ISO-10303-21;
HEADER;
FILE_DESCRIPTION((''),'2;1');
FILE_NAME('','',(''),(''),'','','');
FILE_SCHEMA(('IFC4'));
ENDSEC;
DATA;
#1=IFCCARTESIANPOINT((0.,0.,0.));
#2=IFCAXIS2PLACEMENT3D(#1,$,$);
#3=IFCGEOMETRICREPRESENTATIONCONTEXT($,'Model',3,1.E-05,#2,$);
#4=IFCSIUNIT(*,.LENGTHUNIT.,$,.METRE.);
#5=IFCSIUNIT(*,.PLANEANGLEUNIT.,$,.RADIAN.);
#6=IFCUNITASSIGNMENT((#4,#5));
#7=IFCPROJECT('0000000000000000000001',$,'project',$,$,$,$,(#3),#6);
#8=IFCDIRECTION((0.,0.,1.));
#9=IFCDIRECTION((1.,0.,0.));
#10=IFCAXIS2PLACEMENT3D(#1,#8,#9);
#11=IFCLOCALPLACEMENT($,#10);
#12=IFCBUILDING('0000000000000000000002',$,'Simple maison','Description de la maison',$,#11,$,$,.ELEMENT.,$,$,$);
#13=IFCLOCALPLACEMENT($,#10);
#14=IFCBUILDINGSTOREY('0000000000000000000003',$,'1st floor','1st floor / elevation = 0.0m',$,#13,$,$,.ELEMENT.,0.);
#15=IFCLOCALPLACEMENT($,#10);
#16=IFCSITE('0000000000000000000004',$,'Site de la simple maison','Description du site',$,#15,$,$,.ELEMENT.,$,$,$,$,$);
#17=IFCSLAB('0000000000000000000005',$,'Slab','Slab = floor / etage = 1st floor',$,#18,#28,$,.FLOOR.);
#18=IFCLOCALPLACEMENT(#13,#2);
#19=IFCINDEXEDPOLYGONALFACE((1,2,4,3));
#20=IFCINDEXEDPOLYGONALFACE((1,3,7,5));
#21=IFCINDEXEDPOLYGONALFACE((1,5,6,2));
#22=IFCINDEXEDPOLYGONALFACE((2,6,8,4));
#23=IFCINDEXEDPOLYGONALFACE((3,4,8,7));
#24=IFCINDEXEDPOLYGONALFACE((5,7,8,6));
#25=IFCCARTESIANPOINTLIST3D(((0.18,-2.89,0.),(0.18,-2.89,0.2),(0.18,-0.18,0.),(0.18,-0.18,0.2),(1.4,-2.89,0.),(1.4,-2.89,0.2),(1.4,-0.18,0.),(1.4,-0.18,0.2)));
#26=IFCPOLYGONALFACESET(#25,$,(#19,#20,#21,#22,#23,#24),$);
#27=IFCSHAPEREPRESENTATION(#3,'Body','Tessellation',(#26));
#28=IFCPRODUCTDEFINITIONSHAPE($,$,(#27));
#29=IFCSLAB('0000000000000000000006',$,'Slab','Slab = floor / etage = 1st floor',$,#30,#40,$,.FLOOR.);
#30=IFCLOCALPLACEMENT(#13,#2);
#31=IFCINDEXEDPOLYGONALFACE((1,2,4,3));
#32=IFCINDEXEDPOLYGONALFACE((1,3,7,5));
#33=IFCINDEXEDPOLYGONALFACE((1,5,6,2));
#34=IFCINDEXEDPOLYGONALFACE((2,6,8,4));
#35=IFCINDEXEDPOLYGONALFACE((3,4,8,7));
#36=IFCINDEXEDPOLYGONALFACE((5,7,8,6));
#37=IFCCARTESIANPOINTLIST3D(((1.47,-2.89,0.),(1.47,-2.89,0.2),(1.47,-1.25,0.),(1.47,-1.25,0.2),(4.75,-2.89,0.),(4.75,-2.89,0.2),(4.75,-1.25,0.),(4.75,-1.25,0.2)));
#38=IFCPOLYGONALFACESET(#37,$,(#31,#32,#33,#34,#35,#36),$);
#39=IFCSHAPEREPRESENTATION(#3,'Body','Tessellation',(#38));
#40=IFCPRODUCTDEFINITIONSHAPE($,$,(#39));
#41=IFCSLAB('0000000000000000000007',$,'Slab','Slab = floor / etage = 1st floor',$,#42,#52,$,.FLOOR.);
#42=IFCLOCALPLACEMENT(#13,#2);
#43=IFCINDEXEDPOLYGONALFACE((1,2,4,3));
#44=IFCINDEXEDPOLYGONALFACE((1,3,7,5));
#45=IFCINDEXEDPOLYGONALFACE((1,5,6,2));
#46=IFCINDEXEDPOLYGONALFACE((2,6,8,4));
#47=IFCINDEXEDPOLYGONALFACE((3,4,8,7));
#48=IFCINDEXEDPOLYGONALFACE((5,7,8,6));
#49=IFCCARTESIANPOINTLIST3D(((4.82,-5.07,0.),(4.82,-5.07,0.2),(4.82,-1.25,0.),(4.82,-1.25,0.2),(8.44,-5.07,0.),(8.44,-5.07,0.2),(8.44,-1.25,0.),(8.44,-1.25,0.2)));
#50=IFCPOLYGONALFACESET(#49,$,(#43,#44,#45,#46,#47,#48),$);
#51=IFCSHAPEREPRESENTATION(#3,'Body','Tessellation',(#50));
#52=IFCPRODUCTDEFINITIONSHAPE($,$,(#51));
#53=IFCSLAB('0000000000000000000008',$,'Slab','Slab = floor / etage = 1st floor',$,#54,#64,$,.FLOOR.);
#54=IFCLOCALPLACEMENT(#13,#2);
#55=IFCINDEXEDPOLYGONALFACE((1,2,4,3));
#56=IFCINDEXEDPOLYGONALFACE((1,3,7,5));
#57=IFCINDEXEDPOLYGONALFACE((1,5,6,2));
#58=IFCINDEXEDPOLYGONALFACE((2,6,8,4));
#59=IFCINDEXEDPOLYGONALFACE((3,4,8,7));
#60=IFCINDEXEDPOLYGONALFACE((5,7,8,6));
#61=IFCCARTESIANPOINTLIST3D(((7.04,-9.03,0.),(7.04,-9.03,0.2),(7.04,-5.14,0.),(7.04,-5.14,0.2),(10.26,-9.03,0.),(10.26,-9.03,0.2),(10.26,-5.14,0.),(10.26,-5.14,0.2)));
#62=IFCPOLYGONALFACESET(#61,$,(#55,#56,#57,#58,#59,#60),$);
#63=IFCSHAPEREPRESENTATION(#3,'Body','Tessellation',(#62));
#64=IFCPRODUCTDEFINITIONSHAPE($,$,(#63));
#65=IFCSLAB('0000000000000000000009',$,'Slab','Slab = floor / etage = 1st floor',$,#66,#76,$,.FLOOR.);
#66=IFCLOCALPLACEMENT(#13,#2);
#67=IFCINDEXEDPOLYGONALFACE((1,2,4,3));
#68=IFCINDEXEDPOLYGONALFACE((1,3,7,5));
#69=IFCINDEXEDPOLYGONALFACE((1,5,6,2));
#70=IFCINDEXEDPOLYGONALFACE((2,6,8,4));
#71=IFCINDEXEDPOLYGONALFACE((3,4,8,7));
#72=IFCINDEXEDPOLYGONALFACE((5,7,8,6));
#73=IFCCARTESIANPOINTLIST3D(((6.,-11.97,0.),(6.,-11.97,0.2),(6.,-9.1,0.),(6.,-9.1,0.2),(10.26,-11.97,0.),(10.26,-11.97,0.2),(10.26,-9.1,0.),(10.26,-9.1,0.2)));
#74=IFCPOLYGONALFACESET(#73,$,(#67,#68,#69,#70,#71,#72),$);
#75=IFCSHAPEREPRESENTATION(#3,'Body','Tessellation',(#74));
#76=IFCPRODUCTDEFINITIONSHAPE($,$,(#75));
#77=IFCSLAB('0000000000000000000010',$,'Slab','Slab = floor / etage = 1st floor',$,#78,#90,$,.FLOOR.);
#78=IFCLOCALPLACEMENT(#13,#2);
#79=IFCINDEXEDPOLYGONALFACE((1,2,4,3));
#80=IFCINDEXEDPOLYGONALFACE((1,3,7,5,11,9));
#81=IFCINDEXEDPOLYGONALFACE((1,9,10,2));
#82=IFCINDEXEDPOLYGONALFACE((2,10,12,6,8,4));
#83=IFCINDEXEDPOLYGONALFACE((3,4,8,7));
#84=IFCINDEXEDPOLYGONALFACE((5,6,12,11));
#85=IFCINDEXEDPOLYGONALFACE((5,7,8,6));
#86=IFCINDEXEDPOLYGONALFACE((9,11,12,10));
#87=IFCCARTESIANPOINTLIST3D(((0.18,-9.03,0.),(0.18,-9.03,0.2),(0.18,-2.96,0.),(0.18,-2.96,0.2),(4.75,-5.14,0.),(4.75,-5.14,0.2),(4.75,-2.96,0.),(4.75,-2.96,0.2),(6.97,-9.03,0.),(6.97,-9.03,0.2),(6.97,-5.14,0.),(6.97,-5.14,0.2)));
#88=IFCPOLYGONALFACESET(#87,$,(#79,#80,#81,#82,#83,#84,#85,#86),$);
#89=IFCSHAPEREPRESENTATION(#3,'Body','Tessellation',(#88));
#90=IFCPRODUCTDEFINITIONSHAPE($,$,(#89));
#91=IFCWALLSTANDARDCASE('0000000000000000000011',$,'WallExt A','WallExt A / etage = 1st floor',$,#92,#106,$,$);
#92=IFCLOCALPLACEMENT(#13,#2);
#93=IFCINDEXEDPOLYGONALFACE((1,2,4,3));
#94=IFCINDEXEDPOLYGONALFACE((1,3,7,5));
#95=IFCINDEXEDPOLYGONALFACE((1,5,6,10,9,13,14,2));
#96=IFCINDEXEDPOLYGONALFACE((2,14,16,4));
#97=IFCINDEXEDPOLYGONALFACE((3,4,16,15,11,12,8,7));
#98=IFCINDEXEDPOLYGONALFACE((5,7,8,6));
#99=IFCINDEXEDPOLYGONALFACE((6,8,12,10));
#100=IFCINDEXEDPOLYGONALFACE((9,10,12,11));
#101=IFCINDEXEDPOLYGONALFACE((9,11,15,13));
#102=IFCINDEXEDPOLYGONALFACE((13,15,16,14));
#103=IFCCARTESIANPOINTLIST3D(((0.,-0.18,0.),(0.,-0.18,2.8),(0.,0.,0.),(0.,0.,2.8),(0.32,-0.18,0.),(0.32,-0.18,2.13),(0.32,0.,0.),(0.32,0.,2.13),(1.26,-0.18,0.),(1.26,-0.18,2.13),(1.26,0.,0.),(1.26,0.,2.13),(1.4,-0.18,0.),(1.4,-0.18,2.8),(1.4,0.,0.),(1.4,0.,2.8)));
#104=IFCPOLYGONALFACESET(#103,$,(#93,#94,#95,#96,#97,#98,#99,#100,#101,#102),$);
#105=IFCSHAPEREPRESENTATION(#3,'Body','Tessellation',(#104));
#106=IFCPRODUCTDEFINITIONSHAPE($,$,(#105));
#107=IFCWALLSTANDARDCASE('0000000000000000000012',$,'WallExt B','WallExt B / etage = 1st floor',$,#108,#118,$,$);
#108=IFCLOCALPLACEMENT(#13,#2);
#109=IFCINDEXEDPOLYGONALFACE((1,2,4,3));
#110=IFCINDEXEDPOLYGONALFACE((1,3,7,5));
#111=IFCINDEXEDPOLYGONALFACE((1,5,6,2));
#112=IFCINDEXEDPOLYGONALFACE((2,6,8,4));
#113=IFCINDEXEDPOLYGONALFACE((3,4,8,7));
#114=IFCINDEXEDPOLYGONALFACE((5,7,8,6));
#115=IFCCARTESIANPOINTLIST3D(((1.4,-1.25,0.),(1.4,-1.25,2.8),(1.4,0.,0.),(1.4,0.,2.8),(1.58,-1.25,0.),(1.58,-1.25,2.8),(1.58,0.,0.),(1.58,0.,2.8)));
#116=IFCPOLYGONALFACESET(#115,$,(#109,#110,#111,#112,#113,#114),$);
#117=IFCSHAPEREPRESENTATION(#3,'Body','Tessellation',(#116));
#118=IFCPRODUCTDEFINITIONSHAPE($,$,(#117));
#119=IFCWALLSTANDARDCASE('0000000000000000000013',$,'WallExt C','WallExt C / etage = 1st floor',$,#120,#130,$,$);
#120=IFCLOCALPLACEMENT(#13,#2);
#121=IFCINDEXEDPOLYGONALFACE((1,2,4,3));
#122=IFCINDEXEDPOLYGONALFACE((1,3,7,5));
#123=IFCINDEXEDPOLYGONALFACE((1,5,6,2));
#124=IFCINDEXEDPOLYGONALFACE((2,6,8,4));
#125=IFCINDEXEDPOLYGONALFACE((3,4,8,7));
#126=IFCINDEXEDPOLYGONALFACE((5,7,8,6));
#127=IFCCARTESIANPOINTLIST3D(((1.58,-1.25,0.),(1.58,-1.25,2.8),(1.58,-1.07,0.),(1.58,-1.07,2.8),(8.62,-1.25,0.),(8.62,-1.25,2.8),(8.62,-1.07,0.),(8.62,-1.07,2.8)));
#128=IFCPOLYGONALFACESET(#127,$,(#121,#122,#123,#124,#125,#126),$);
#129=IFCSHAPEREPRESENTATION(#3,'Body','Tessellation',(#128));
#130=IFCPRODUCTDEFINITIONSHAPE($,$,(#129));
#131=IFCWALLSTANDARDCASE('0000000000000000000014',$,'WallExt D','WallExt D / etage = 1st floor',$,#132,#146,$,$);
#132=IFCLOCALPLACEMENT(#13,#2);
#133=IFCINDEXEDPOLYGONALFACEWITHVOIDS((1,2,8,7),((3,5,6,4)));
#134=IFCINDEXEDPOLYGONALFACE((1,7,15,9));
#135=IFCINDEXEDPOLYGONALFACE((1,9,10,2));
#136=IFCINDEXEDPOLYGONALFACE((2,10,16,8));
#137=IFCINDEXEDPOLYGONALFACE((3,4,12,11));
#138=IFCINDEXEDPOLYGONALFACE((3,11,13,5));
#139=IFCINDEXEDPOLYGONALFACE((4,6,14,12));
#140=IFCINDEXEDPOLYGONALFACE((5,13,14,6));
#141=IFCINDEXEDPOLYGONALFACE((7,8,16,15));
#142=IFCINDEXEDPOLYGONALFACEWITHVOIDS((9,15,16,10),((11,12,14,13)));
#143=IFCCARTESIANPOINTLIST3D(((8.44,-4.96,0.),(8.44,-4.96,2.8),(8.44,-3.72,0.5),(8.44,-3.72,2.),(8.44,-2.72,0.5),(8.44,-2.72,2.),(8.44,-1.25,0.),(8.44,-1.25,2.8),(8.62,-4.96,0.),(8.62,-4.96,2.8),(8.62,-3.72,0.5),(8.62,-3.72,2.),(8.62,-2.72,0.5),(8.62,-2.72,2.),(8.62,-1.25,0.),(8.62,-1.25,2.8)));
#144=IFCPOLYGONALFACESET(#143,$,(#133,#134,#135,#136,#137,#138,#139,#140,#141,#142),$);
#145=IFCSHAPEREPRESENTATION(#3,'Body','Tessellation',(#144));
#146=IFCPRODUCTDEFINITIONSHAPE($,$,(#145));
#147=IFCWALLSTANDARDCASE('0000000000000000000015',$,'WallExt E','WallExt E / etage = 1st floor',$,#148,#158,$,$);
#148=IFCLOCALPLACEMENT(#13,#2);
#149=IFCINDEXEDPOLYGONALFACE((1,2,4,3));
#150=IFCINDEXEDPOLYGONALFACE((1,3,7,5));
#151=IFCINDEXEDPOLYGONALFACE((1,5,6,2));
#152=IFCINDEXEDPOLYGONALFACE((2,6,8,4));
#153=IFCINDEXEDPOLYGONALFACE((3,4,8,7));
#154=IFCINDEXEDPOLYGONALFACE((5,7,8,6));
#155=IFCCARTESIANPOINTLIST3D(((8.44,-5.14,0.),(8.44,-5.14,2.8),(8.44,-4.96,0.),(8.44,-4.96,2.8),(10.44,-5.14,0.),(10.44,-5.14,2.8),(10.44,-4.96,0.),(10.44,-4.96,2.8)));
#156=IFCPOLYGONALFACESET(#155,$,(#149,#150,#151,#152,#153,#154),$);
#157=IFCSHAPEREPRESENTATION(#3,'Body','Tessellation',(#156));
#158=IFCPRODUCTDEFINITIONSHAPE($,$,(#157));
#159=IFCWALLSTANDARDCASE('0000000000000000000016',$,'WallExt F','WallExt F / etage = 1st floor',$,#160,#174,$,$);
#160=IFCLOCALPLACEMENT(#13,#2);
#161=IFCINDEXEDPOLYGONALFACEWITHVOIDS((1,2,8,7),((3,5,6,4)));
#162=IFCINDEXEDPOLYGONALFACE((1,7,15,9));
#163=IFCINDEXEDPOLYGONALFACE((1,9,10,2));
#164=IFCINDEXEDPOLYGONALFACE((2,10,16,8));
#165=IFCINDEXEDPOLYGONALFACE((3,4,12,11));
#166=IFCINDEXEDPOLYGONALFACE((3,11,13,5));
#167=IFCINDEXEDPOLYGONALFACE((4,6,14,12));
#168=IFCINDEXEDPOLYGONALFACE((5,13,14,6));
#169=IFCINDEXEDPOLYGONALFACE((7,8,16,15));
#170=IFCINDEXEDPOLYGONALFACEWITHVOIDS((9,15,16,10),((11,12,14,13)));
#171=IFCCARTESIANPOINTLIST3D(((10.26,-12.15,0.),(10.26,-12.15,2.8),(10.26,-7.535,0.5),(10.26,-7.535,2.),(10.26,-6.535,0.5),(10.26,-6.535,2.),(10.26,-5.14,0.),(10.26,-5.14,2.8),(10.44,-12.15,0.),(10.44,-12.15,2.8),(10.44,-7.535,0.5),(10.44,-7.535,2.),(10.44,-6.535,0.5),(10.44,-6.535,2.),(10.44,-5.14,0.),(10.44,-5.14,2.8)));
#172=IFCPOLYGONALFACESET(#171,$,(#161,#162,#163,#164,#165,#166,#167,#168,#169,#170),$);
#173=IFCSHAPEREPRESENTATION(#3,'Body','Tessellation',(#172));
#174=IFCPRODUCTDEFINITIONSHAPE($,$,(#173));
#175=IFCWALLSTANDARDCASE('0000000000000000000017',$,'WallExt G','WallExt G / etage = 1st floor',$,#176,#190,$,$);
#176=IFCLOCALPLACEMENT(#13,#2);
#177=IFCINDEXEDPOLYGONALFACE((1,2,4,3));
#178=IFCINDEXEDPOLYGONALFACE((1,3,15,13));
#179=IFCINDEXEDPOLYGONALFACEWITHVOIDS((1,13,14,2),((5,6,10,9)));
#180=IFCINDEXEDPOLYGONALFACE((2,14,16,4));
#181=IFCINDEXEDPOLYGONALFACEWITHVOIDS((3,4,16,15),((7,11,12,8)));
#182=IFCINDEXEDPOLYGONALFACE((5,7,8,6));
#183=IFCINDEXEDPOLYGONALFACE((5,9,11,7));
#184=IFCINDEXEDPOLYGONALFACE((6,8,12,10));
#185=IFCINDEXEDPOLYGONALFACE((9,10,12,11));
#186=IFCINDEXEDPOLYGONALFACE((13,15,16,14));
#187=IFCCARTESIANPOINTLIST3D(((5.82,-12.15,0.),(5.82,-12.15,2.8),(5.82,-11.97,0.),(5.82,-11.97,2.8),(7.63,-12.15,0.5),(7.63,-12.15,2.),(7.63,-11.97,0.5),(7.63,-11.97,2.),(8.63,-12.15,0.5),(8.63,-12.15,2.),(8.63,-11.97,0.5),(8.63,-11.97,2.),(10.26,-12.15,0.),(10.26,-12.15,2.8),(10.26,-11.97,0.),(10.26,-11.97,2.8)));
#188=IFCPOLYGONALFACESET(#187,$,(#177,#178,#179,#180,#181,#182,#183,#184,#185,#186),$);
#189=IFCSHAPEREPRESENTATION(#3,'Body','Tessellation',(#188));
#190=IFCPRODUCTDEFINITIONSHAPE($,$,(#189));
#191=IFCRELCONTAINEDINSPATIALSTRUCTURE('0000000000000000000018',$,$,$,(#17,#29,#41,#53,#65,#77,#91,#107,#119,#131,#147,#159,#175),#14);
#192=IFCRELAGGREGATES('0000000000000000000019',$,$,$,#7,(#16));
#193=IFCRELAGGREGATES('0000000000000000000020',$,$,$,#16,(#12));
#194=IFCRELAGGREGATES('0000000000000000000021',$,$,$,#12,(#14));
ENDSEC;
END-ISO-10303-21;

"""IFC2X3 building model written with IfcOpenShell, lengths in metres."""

from ifc_helpers import new_model, si_unit, frame, origin, origin_with_axes, origin_2d_with_axis, place, context, project, spatial, polyline, rectangle, outline, extrude, element, save


model = new_model("IFC2X3")

# Units and contexts
model_context = context("Model", 3, precision=1e-05, world=origin())
ifc_project = project(units=[si_unit("LENGTHUNIT", "METRE"), si_unit("PLANEANGLEUNIT", "RADIAN")], contexts=[model_context])

# Site, building, storey
site_placement = place(None, origin_with_axes())
site = spatial("IfcSite", under=ifc_project, at=site_placement, Name="Site de la simple maison", Description="Description du site", CompositionType="ELEMENT")
building_placement = place(None, origin_with_axes())
building = spatial("IfcBuilding", under=site, at=building_placement, Name="Simple maison", Description="Description de la maison", CompositionType="ELEMENT")
storey_placement = place(None, origin_with_axes())
storey = spatial("IfcBuildingStorey", under=building, at=storey_placement, Name="1st floor", Description="1st floor / elevation = 0.0m", CompositionType="ELEMENT", Elevation=0.0)

# Slabs
slab_1_placement = place(storey_placement, origin_with_axes())
element("IfcSlab", 1, at=slab_1_placement, inside=storey, Name="Slab", Description="Slab = floor / etage = 1st floor", PredefinedType="FLOOR", context=model_context, shape_type="SweptSolid", body=[
    extrude(outline(polyline([(0.18, -0.18), (1.4, -0.18), (1.4, -2.89), (0.18, -2.89)])), origin(), (0.0, 0.0, 1.0), 0.2),
])
slab_2_placement = place(storey_placement, origin_with_axes())
element("IfcSlab", 2, at=slab_2_placement, inside=storey, Name="Slab", Description="Slab = floor / etage = 1st floor", PredefinedType="FLOOR", context=model_context, shape_type="SweptSolid", body=[
    extrude(outline(polyline([(1.47, -1.25), (4.75, -1.25), (4.75, -2.89), (1.47, -2.89)])), origin(), (0.0, 0.0, 1.0), 0.2),
])
slab_3_placement = place(storey_placement, origin_with_axes())
element("IfcSlab", 3, at=slab_3_placement, inside=storey, Name="Slab", Description="Slab = floor / etage = 1st floor", PredefinedType="FLOOR", context=model_context, shape_type="SweptSolid", body=[
    extrude(outline(polyline([(4.82, -1.25), (8.44, -1.25), (8.44, -5.07), (4.82, -5.07)])), origin(), (0.0, 0.0, 1.0), 0.2),
])
slab_4_placement = place(storey_placement, origin_with_axes())
element("IfcSlab", 4, at=slab_4_placement, inside=storey, Name="Slab", Description="Slab = floor / etage = 1st floor", PredefinedType="FLOOR", context=model_context, shape_type="SweptSolid", body=[
    extrude(outline(polyline([(7.04, -5.14), (10.26, -5.14), (10.26, -9.03), (7.04, -9.03)])), origin(), (0.0, 0.0, 1.0), 0.2),
])
slab_5_placement = place(storey_placement, origin_with_axes())
element("IfcSlab", 5, at=slab_5_placement, inside=storey, Name="Slab", Description="Slab = floor / etage = 1st floor", PredefinedType="FLOOR", context=model_context, shape_type="SweptSolid", body=[
    extrude(outline(polyline([(6.0, -9.1), (10.26, -9.1), (10.26, -11.97), (6.0, -11.97)])), origin(), (0.0, 0.0, 1.0), 0.2),
])
slab_6_placement = place(storey_placement, origin_with_axes())
element("IfcSlab", 6, at=slab_6_placement, inside=storey, Name="Slab", Description="Slab = floor / etage = 1st floor", PredefinedType="FLOOR", context=model_context, shape_type="SweptSolid", body=[
    extrude(outline(polyline([(0.18, -2.96), (4.75, -2.96), (4.75, -5.14), (6.97, -5.14), (6.97, -9.03), (0.18, -9.03)])), origin(), (0.0, 0.0, 1.0), 0.2),
])

# Wall, opening
wall_1_placement = place(storey_placement, frame((0.0, -0.09, 0.0), z_axis=(0.0, 0.0, 1.0), x_axis=(1.0, 0.0, 0.0)))
wall_1 = element("IfcWallStandardCase", 7, at=wall_1_placement, inside=storey, Name="WallExt A", Description="WallExt A / etage = 1st floor", context=model_context, shape_type="SweptSolid", body=[
    extrude(outline(polyline([(0.0, 0.09), (1.4, 0.09), (1.4, -0.09), (0.0, -0.09)])), origin(), (0.0, 0.0, 1.0), 2.8),
])
opening_1_placement = place(wall_1_placement, frame((0.32, -0.09, 0.0), z_axis=(0.0, 0.0, 1.0), x_axis=(1.0, 0.0, 0.0)))
element("IfcOpeningElement", 8, at=opening_1_placement, cuts=wall_1, context=model_context, shape_type="SweptSolid", body=[
    extrude(rectangle(XDim=2.13, YDim=0.94, at=origin_2d_with_axis()), frame((0.47, 0.0, 1.065), z_axis=(0.0, 1.0, 0.0), x_axis=(0.0, 0.0, 1.0)), (0.0, 0.0, 1.0), 0.18),
])

# Walls
wall_2_placement = place(storey_placement, frame((1.49, 0.0, 0.0), z_axis=(0.0, 0.0, 1.0), x_axis=(0.0, -1.0, 0.0)))
element("IfcWallStandardCase", 9, at=wall_2_placement, inside=storey, Name="WallExt B", Description="WallExt B / etage = 1st floor", context=model_context, shape_type="SweptSolid", body=[
    extrude(outline(polyline([(0.0, 0.09), (1.25, 0.09), (1.25, -0.09), (0.0, -0.09)])), origin(), (0.0, 0.0, 1.0), 2.8),
])
wall_3_placement = place(storey_placement, frame((1.58, -1.16, 0.0), z_axis=(0.0, 0.0, 1.0), x_axis=(1.0, 0.0, 0.0)))
element("IfcWallStandardCase", 10, at=wall_3_placement, inside=storey, Name="WallExt C", Description="WallExt C / etage = 1st floor", context=model_context, shape_type="SweptSolid", body=[
    extrude(outline(polyline([(0.0, 0.09), (7.04, 0.09), (7.04, -0.09), (0.0, -0.09)])), origin(), (0.0, 0.0, 1.0), 2.8),
])

# Wall, opening
wall_4_placement = place(storey_placement, frame((8.53, -1.25, 0.0), z_axis=(0.0, 0.0, 1.0), x_axis=(0.0, -1.0, 0.0)))
wall_4 = element("IfcWallStandardCase", 11, at=wall_4_placement, inside=storey, Name="WallExt D", Description="WallExt D / etage = 1st floor", context=model_context, shape_type="SweptSolid", body=[
    extrude(outline(polyline([(0.0, 0.09), (3.71, 0.09), (3.71, -0.09), (0.0, -0.09)])), origin(), (0.0, 0.0, 1.0), 2.8),
])
opening_2_placement = place(wall_4_placement, frame((1.47, -0.09, 0.5), z_axis=(0.0, 0.0, 1.0), x_axis=(1.0, 0.0, 0.0)))
element("IfcOpeningElement", 12, at=opening_2_placement, cuts=wall_4, context=model_context, shape_type="SweptSolid", body=[
    extrude(rectangle(XDim=1.5, YDim=1.0, at=origin_2d_with_axis()), frame((0.5, 0.0, 0.75), z_axis=(0.0, 1.0, 0.0), x_axis=(0.0, 0.0, 1.0)), (0.0, 0.0, 1.0), 0.18),
])

# Wall
wall_5_placement = place(storey_placement, frame((8.44, -5.05, 0.0), z_axis=(0.0, 0.0, 1.0), x_axis=(1.0, 0.0, 0.0)))
element("IfcWallStandardCase", 13, at=wall_5_placement, inside=storey, Name="WallExt E", Description="WallExt E / etage = 1st floor", context=model_context, shape_type="SweptSolid", body=[
    extrude(outline(polyline([(0.0, 0.09), (2.0, 0.09), (2.0, -0.09), (0.0, -0.09)])), origin(), (0.0, 0.0, 1.0), 2.8),
])

# Walls, openings
wall_6_placement = place(storey_placement, frame((10.35, -5.14, 0.0), z_axis=(0.0, 0.0, 1.0), x_axis=(0.0, -1.0, 0.0)))
wall_6 = element("IfcWallStandardCase", 14, at=wall_6_placement, inside=storey, Name="WallExt F", Description="WallExt F / etage = 1st floor", context=model_context, shape_type="SweptSolid", body=[
    extrude(outline(polyline([(0.0, 0.09), (7.01, 0.09), (7.01, -0.09), (0.0, -0.09)])), origin(), (0.0, 0.0, 1.0), 2.8),
])
opening_3_placement = place(wall_6_placement, frame((1.395, -0.09, 0.5), z_axis=(0.0, 0.0, 1.0), x_axis=(1.0, 0.0, 0.0)))
element("IfcOpeningElement", 15, at=opening_3_placement, cuts=wall_6, context=model_context, shape_type="SweptSolid", body=[
    extrude(rectangle(XDim=1.5, YDim=1.0, at=origin_2d_with_axis()), frame((0.5, 0.0, 0.75), z_axis=(0.0, 1.0, 0.0), x_axis=(0.0, 0.0, 1.0)), (0.0, 0.0, 1.0), 0.18),
])
wall_7_placement = place(storey_placement, frame((10.26, -12.06, 0.0), z_axis=(0.0, 0.0, 1.0), x_axis=(-1.0, 0.0, 0.0)))
wall_7 = element("IfcWallStandardCase", 16, at=wall_7_placement, inside=storey, Name="WallExt G", Description="WallExt G / etage = 1st floor", context=model_context, shape_type="SweptSolid", body=[
    extrude(outline(polyline([(0.0, 0.09), (4.44, 0.09), (4.44, -0.09), (0.0, -0.09)])), origin(), (0.0, 0.0, 1.0), 2.8),
])
opening_4_placement = place(wall_7_placement, frame((1.63, -0.09, 0.5), z_axis=(0.0, 0.0, 1.0), x_axis=(1.0, 0.0, 0.0)))
element("IfcOpeningElement", 17, at=opening_4_placement, cuts=wall_7, context=model_context, shape_type="SweptSolid", body=[
    extrude(rectangle(XDim=1.5, YDim=1.0, at=origin_2d_with_axis()), frame((0.5, 0.0, 0.75), z_axis=(0.0, 1.0, 0.0), x_axis=(0.0, 0.0, 1.0)), (0.0, 0.0, 1.0), 0.18),
])

save(model, "model.ifc")
